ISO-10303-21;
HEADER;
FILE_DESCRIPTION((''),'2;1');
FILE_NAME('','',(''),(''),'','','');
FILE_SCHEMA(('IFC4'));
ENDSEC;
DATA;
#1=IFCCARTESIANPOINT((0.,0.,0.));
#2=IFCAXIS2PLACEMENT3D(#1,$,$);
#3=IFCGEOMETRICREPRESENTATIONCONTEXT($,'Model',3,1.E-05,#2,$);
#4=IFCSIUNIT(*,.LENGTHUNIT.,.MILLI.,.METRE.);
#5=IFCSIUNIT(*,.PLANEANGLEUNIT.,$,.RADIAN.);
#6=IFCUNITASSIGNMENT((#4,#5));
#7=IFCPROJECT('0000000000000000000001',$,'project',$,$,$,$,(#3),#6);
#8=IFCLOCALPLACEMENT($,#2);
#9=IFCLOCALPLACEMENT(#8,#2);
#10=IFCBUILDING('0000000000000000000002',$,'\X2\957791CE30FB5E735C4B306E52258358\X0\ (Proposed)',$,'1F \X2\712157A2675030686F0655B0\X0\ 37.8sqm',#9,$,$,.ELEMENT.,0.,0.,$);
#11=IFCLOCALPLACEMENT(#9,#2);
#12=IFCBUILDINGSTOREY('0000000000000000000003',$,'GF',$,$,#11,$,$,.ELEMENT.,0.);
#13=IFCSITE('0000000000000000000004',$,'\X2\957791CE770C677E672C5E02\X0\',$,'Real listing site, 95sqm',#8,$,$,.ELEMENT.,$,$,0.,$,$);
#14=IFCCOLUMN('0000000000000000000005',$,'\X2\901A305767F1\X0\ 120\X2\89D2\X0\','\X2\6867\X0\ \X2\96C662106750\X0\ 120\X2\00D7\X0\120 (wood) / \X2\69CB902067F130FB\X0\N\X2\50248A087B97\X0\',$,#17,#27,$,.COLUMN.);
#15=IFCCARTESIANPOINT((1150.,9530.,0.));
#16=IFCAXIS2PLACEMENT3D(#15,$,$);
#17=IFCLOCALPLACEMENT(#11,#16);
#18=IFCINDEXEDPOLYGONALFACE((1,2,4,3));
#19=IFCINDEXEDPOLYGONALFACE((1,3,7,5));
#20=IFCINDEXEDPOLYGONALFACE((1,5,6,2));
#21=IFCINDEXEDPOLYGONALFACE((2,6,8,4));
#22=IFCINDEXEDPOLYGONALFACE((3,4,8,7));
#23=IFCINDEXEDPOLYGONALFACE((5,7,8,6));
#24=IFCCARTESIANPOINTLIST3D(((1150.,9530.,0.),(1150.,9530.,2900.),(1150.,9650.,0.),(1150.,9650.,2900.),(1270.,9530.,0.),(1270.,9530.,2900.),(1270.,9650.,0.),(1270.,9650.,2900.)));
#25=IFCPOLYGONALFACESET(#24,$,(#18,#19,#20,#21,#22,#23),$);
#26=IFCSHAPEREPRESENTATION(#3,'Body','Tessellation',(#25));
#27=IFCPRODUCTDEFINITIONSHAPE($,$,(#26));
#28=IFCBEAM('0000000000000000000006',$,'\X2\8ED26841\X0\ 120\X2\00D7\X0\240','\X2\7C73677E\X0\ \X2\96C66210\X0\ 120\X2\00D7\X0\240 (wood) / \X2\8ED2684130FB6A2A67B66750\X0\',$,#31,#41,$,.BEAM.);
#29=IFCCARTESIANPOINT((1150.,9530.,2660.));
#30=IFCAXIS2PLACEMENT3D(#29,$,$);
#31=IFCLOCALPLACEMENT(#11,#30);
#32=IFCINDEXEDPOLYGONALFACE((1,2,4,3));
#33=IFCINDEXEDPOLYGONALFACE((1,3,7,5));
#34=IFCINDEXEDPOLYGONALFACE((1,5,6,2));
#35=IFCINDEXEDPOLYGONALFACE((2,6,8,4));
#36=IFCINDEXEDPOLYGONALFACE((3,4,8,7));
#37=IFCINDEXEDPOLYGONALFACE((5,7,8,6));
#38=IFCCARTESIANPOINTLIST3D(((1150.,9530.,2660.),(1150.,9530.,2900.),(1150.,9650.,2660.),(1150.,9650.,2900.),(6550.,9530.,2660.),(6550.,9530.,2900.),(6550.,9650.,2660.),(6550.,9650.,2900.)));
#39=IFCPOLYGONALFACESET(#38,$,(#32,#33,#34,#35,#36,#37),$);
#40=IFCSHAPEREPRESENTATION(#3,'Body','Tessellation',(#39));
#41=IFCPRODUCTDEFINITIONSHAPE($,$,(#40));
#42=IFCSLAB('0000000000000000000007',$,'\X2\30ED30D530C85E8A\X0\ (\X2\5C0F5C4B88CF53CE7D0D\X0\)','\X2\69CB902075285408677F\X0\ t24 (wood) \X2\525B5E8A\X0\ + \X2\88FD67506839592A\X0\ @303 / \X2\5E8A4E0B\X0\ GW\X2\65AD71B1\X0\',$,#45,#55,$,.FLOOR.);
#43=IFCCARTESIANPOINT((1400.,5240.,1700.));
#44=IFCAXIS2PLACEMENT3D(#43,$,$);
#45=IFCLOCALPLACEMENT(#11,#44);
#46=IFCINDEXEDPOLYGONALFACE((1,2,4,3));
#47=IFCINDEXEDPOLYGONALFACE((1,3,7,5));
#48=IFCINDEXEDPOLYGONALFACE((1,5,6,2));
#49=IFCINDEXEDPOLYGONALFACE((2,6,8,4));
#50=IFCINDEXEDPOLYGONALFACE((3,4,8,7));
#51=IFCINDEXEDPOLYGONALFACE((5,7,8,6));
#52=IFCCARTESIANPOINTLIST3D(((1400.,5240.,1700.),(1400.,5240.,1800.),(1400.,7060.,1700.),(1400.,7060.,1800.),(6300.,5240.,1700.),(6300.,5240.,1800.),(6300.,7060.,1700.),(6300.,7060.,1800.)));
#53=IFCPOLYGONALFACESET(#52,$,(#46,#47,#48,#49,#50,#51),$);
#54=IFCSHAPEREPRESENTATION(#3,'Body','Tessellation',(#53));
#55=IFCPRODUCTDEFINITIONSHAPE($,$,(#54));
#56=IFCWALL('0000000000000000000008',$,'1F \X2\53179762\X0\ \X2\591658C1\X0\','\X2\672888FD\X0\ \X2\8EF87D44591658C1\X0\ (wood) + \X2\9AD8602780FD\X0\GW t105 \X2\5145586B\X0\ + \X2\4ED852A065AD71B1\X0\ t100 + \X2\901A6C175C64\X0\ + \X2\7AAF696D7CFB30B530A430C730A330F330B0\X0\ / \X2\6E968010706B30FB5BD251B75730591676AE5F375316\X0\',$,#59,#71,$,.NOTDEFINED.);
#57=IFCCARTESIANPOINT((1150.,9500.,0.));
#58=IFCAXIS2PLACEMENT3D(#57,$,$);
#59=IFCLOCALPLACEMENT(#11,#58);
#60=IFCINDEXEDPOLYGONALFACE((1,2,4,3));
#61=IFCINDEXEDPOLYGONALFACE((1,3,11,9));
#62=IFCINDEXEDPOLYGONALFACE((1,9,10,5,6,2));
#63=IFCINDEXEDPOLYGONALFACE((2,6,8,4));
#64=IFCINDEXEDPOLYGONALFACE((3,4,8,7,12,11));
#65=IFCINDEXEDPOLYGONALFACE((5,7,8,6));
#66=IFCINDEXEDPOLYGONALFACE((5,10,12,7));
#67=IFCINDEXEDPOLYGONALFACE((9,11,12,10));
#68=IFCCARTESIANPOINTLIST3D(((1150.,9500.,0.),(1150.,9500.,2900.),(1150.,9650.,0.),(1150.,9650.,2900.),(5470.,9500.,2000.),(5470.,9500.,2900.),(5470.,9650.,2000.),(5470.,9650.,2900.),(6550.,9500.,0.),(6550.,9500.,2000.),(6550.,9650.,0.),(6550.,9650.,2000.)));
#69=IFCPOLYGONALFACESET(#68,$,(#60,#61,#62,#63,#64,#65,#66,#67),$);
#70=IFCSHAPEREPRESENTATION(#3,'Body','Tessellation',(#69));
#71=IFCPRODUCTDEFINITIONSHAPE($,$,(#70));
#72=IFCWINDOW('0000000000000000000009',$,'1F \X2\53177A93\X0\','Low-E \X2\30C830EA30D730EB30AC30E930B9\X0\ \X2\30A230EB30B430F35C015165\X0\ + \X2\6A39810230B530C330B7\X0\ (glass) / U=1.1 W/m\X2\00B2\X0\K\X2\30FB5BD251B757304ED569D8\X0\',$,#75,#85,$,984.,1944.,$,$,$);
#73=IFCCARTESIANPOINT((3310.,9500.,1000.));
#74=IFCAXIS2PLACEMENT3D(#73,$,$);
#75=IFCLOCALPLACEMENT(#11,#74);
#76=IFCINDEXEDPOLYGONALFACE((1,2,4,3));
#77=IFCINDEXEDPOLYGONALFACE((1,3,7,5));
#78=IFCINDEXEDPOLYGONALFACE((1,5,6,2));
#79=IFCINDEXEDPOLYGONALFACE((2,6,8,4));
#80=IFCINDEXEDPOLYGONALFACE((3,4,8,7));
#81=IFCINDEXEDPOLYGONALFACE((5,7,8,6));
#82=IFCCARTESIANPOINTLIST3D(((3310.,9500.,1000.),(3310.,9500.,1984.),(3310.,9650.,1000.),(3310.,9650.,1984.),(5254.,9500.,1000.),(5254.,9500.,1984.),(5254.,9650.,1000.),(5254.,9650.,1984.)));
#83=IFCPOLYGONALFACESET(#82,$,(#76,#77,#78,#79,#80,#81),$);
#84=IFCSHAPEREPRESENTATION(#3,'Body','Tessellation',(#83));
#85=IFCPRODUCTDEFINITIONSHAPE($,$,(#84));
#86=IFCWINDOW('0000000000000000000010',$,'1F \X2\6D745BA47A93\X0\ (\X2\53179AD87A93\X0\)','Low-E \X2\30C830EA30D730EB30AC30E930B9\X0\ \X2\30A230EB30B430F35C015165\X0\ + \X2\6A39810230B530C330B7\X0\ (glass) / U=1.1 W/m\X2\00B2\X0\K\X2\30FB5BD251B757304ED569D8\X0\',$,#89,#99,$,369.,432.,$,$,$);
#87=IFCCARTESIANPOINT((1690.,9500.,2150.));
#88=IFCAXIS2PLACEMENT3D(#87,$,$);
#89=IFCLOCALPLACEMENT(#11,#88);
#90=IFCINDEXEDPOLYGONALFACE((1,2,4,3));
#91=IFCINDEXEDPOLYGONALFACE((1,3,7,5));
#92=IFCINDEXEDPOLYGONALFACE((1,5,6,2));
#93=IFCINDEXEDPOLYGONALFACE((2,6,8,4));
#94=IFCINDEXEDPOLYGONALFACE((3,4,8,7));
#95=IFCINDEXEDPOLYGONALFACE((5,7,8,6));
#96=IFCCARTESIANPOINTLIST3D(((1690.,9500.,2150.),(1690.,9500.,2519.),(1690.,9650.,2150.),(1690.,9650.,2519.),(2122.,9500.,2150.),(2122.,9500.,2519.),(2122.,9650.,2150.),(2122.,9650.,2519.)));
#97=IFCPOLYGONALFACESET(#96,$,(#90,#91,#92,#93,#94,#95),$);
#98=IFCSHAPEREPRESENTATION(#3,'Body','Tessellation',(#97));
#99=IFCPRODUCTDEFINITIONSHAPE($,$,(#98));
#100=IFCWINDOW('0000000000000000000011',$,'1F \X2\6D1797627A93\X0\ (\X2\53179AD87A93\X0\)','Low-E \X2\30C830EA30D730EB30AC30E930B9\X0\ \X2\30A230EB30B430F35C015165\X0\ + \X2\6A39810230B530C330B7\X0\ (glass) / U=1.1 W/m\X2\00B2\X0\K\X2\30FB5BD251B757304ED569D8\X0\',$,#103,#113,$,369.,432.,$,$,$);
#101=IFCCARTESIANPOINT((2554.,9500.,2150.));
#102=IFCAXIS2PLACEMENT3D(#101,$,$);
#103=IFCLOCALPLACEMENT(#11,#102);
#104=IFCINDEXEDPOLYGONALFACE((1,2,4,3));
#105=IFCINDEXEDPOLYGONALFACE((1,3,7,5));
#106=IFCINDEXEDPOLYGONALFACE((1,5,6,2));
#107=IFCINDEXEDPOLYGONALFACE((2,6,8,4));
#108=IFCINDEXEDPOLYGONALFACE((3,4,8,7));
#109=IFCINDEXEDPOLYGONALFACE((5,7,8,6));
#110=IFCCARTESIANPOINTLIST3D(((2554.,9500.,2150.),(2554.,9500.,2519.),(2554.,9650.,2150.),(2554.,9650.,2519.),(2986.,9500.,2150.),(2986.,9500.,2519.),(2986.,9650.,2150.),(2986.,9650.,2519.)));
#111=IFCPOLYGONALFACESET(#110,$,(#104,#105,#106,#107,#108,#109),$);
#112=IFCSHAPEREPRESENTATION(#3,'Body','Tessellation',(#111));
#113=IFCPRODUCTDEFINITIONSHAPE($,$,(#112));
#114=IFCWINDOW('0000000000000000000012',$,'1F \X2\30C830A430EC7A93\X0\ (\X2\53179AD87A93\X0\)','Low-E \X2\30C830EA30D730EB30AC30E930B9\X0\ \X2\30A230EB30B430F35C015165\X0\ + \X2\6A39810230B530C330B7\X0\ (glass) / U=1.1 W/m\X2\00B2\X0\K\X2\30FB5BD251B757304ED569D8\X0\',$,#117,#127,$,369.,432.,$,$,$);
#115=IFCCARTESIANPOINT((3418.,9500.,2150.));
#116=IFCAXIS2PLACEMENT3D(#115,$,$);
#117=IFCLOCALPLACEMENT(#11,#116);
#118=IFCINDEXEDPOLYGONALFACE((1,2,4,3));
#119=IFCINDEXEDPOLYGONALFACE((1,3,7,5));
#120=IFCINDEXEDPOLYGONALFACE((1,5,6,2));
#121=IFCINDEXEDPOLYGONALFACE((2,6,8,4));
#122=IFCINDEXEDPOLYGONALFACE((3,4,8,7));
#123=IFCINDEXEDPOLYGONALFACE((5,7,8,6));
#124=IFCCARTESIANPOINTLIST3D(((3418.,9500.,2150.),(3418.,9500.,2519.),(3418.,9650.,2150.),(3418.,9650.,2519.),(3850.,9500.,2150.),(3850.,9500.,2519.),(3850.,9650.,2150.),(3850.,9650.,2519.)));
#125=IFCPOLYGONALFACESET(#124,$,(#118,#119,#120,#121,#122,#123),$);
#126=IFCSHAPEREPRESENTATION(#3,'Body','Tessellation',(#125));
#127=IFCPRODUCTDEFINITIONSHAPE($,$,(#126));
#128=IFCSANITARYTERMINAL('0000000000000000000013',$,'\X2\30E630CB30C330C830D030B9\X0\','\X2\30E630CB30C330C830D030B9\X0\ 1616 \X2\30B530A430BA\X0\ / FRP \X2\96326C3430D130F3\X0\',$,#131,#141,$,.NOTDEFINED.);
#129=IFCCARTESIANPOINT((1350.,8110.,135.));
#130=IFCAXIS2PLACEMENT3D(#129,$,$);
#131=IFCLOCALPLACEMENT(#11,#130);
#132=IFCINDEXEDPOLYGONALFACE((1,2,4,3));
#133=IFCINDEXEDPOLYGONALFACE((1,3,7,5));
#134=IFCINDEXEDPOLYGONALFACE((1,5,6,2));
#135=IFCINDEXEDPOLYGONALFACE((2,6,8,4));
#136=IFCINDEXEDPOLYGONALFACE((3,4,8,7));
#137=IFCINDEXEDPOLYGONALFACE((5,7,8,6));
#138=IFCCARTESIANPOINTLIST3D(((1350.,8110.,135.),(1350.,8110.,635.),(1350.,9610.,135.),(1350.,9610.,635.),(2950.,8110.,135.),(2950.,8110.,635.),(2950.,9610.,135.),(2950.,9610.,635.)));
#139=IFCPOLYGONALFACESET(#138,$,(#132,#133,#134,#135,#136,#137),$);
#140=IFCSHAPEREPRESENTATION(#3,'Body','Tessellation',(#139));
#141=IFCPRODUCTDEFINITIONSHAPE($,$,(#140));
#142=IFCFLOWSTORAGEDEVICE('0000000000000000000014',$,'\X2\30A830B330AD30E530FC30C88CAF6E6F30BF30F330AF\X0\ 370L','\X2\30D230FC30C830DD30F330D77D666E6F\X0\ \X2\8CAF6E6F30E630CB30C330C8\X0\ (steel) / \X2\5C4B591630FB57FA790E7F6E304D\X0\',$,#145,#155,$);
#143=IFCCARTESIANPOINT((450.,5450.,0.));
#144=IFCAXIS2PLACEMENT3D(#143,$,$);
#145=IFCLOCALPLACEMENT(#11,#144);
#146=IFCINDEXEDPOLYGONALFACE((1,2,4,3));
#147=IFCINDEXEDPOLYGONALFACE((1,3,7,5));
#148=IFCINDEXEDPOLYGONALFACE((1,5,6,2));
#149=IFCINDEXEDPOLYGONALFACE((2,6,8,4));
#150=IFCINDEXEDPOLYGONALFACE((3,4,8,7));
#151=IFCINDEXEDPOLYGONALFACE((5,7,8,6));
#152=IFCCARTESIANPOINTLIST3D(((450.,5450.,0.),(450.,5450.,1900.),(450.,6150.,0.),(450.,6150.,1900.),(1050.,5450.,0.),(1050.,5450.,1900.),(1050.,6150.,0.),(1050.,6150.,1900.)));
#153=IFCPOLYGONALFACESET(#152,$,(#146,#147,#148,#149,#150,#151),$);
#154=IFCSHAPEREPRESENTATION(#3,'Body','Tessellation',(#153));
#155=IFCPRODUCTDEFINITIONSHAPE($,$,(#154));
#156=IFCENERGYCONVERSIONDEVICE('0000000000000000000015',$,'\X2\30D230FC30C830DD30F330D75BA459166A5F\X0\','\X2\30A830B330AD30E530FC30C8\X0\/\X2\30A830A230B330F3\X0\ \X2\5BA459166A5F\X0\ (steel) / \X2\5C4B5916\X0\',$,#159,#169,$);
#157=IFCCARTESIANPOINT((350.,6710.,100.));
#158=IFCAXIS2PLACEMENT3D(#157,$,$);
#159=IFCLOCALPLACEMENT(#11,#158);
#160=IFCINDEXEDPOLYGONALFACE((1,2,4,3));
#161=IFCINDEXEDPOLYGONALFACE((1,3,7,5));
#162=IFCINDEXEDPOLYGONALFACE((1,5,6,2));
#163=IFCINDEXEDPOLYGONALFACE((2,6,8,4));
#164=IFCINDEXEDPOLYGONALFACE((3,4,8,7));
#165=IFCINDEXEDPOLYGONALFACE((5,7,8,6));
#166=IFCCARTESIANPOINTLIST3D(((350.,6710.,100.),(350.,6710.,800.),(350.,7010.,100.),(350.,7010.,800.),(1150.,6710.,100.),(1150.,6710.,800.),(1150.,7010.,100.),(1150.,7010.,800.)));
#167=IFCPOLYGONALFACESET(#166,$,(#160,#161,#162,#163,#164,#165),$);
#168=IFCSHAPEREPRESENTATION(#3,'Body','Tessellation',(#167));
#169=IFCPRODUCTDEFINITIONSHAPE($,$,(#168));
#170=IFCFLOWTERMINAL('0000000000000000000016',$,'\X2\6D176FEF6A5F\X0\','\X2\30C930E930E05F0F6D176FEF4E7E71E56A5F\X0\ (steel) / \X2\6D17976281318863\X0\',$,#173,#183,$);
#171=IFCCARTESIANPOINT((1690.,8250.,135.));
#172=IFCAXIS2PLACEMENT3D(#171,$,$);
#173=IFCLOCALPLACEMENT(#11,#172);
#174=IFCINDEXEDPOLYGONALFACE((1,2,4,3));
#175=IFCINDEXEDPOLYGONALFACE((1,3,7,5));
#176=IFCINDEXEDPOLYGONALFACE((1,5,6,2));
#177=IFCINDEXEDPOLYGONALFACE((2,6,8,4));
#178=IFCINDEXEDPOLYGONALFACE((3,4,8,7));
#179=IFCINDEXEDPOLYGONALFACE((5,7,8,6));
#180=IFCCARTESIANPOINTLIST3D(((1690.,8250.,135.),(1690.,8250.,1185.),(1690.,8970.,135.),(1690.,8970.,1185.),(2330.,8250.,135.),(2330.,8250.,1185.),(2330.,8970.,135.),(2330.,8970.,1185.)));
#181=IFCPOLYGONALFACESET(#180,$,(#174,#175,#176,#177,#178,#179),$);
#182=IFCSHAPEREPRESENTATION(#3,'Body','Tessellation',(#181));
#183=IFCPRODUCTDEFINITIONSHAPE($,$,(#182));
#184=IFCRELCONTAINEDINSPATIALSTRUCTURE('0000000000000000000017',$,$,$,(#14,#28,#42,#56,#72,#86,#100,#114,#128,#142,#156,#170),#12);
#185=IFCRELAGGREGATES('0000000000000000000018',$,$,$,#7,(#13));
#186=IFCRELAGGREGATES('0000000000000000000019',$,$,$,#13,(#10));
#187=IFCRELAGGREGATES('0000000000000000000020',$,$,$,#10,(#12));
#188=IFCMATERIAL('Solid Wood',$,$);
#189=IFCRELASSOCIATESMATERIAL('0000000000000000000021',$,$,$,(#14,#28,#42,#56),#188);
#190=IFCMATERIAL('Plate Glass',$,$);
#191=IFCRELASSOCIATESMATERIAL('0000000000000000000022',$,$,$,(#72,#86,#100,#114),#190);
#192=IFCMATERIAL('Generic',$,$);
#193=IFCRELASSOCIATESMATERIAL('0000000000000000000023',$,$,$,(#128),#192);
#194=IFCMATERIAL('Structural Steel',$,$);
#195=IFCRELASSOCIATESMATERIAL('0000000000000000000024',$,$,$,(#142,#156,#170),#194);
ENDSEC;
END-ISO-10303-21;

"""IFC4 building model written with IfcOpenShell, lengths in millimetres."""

from ifc_helpers import new_model, si_unit, frame, frame_2d, origin, place, context, project, spatial, rectangle, extrude, material, element, fill, save


model = new_model("IFC4")

# Units and contexts
model_context = context("Model", 3, precision=1e-05, world=origin())
ifc_project = project(units=[si_unit("LENGTHUNIT", "METRE", prefix="MILLI"), si_unit("PLANEANGLEUNIT", "RADIAN")], contexts=[model_context])

# Site, building, storey
site_placement = place(None, origin())
site = spatial("IfcSite", under=ifc_project, at=site_placement, Name="長野県松本市", ObjectType="Real listing site, 95sqm", CompositionType="ELEMENT", RefElevation=0.0)
building_placement = place(site_placement, origin())
building = spatial("IfcBuilding", under=site, at=building_placement, Name="長野・平屋の別荘 (Proposed)", ObjectType="1F 無垢材と漆喰 37.8sqm", CompositionType="ELEMENT", ElevationOfRefHeight=0.0, ElevationOfTerrain=0.0)
storey_placement = place(building_placement, origin())
storey = spatial("IfcBuildingStorey", under=building, at=storey_placement, Name="GF", CompositionType="ELEMENT", Elevation=0.0)

# Column
ifc_material_1 = material(Name="Solid Wood")
column_1_placement = place(storey_placement, frame((1150.0, 9530.0, 0.0)))
element("IfcColumn", 1, at=column_1_placement, inside=storey, material=ifc_material_1, Name="通し柱 120角", Description="桧 集成材 120×120 (wood) / 構造柱・N値計算", PredefinedType="COLUMN", context=model_context, shape_type="SweptSolid", body=[
    extrude(rectangle(XDim=120.0, YDim=120.0, at=frame_2d((60.0, 60.0))), frame((1150.0, 9530.0, 0.0)), (0.0, 0.0, 1.0), 2900.0),
])

# Beam
beam_1_placement = place(storey_placement, frame((1150.0, 9530.0, 2660.0)))
element("IfcBeam", 2, at=beam_1_placement, inside=storey, material=ifc_material_1, Name="軒桁 120×240", Description="米松 集成 120×240 (wood) / 軒桁・横架材", PredefinedType="BEAM", context=model_context, shape_type="SweptSolid", body=[
    extrude(rectangle(XDim=5400.0, YDim=120.0, at=frame_2d((2700.0, 60.0))), frame((1150.0, 9530.0, 2660.0)), (0.0, 0.0, 1.0), 240.0),
])

# Slab
slab_placement = place(storey_placement, frame((1400.0, 5240.0, 1700.0)))
element("IfcSlab", 3, at=slab_placement, inside=storey, material=ifc_material_1, Name="ロフト床 (小屋裏収納)", Description="構造用合板 t24 (wood) 剛床 + 製材根太 @303 / 床下 GW断熱", PredefinedType="FLOOR", context=model_context, shape_type="SweptSolid", body=[
    extrude(rectangle(XDim=4900.0, YDim=1820.0, at=frame_2d((2450.0, 910.0))), frame((1400.0, 5240.0, 1700.0)), (0.0, 0.0, 1.0), 100.0),
])

# Wall, openings, windows
wall_1_placement = place(storey_placement, frame((1150.0, 9500.0, 0.0)))
wall_1 = element("IfcWall", 4, at=wall_1_placement, inside=storey, material=ifc_material_1, Name="1F 北面 外壁", Description="木製 軸組外壁 (wood) + 高性能GW t105 充填 + 付加断熱 t100 + 通気層 + 窯業系サイディング / 準耐火・寒冷地外皮強化", PredefinedType="NOTDEFINED", context=model_context, shape_type="SweptSolid", body=[
    extrude(rectangle(XDim=5400.0, YDim=150.0, at=frame_2d((2700.0, 75.0))), frame((1150.0, 9500.0, 0.0)), (0.0, 0.0, 1.0), 2900.0),
])
opening_1_placement = place(storey_placement, frame((3310.0, 9500.0, 1000.0)))
opening_1 = element("IfcOpeningElement", 5, at=opening_1_placement, cuts=wall_1, PredefinedType="NOTDEFINED", context=model_context, shape_type="SweptSolid", body=[
    extrude(rectangle(XDim=1944.0, YDim=150.0, at=frame_2d((972.0, 75.0))), frame((3310.0, 9500.0, 1000.0)), (0.0, 0.0, 1.0), 984.0),
])
opening_2_placement = place(storey_placement, frame((1690.0, 9500.0, 2150.0)))
opening_2 = element("IfcOpeningElement", 6, at=opening_2_placement, cuts=wall_1, PredefinedType="NOTDEFINED", context=model_context, shape_type="SweptSolid", body=[
    extrude(rectangle(XDim=432.0, YDim=150.0, at=frame_2d((216.0, 75.0))), frame((1690.0, 9500.0, 2150.0)), (0.0, 0.0, 1.0), 369.0),
])
opening_3_placement = place(storey_placement, frame((2554.0, 9500.0, 2150.0)))
opening_3 = element("IfcOpeningElement", 7, at=opening_3_placement, cuts=wall_1, PredefinedType="NOTDEFINED", context=model_context, shape_type="SweptSolid", body=[
    extrude(rectangle(XDim=432.0, YDim=150.0, at=frame_2d((216.0, 75.0))), frame((2554.0, 9500.0, 2150.0)), (0.0, 0.0, 1.0), 369.0),
])
opening_4_placement = place(storey_placement, frame((3418.0, 9500.0, 2150.0)))
opening_4 = element("IfcOpeningElement", 8, at=opening_4_placement, cuts=wall_1, PredefinedType="NOTDEFINED", context=model_context, shape_type="SweptSolid", body=[
    extrude(rectangle(XDim=432.0, YDim=150.0, at=frame_2d((216.0, 75.0))), frame((3418.0, 9500.0, 2150.0)), (0.0, 0.0, 1.0), 369.0),
])
ifc_material_2 = material(Name="Plate Glass")
window_1_placement = place(storey_placement, frame((3310.0, 9500.0, 1000.0)))
window_1 = element("IfcWindow", 9, at=window_1_placement, inside=storey, material=ifc_material_2, Name="1F 北窓", Description="Low-E トリプルガラス アルゴン封入 + 樹脂サッシ (glass) / U=1.1 W/m²K・寒冷地仕様", OverallHeight=984.0, OverallWidth=1944.0, context=model_context, shape_type="SweptSolid", body=[
    extrude(rectangle(XDim=1944.0, YDim=150.0, at=frame_2d((972.0, 75.0))), frame((3310.0, 9500.0, 1000.0)), (0.0, 0.0, 1.0), 984.0),
])
fill(opening_1, window_1)
window_2_placement = place(storey_placement, frame((1690.0, 9500.0, 2150.0)))
window_2 = element("IfcWindow", 10, at=window_2_placement, inside=storey, material=ifc_material_2, Name="1F 浴室窓 (北高窓)", Description="Low-E トリプルガラス アルゴン封入 + 樹脂サッシ (glass) / U=1.1 W/m²K・寒冷地仕様", OverallHeight=369.0, OverallWidth=432.0, context=model_context, shape_type="SweptSolid", body=[
    extrude(rectangle(XDim=432.0, YDim=150.0, at=frame_2d((216.0, 75.0))), frame((1690.0, 9500.0, 2150.0)), (0.0, 0.0, 1.0), 369.0),
])
fill(opening_2, window_2)
window_3_placement = place(storey_placement, frame((2554.0, 9500.0, 2150.0)))
window_3 = element("IfcWindow", 11, at=window_3_placement, inside=storey, material=ifc_material_2, Name="1F 洗面窓 (北高窓)", Description="Low-E トリプルガラス アルゴン封入 + 樹脂サッシ (glass) / U=1.1 W/m²K・寒冷地仕様", OverallHeight=369.0, OverallWidth=432.0, context=model_context, shape_type="SweptSolid", body=[
    extrude(rectangle(XDim=432.0, YDim=150.0, at=frame_2d((216.0, 75.0))), frame((2554.0, 9500.0, 2150.0)), (0.0, 0.0, 1.0), 369.0),
])
fill(opening_3, window_3)
window_4_placement = place(storey_placement, frame((3418.0, 9500.0, 2150.0)))
window_4 = element("IfcWindow", 12, at=window_4_placement, inside=storey, material=ifc_material_2, Name="1F トイレ窓 (北高窓)", Description="Low-E トリプルガラス アルゴン封入 + 樹脂サッシ (glass) / U=1.1 W/m²K・寒冷地仕様", OverallHeight=369.0, OverallWidth=432.0, context=model_context, shape_type="SweptSolid", body=[
    extrude(rectangle(XDim=432.0, YDim=150.0, at=frame_2d((216.0, 75.0))), frame((3418.0, 9500.0, 2150.0)), (0.0, 0.0, 1.0), 369.0),
])
fill(opening_4, window_4)

# Sanitary terminal
ifc_material_3 = material(Name="Generic")
sanitary_terminal_placement = place(storey_placement, frame((1350.0, 8110.0, 135.0)))
element("IfcSanitaryTerminal", 13, at=sanitary_terminal_placement, inside=storey, material=ifc_material_3, Name="ユニットバス", Description="ユニットバス 1616 サイズ / FRP 防水パン", PredefinedType="NOTDEFINED", context=model_context, shape_type="SweptSolid", body=[
    extrude(rectangle(XDim=1600.0, YDim=1500.0, at=frame_2d((800.0, 750.0))), frame((1350.0, 8110.0, 135.0)), (0.0, 0.0, 1.0), 500.0),
])

# Flow storage device
ifc_material_4 = material(Name="Structural Steel")
flow_storage_device_placement = place(storey_placement, frame((450.0, 5450.0, 0.0)))
element("IfcFlowStorageDevice", 14, at=flow_storage_device_placement, inside=storey, material=ifc_material_4, Name="エコキュート貯湯タンク 370L", Description="ヒートポンプ給湯 貯湯ユニット (steel) / 屋外・基礎置き", context=model_context, shape_type="SweptSolid", body=[
    extrude(rectangle(XDim=600.0, YDim=700.0, at=frame_2d((300.0, 350.0))), frame((450.0, 5450.0, 0.0)), (0.0, 0.0, 1.0), 1900.0),
])

# Energy conversion device
energy_conversion_device_placement = place(storey_placement, frame((350.0, 6710.0, 100.0)))
element("IfcEnergyConversionDevice", 15, at=energy_conversion_device_placement, inside=storey, material=ifc_material_4, Name="ヒートポンプ室外機", Description="エコキュート/エアコン 室外機 (steel) / 屋外", context=model_context, shape_type="SweptSolid", body=[
    extrude(rectangle(XDim=800.0, YDim=300.0, at=frame_2d((400.0, 150.0))), frame((350.0, 6710.0, 100.0)), (0.0, 0.0, 1.0), 700.0),
])

# Flow terminal
flow_terminal_placement = place(storey_placement, frame((1690.0, 8250.0, 135.0)))
element("IfcFlowTerminal", 16, at=flow_terminal_placement, inside=storey, material=ifc_material_4, Name="洗濯機", Description="ドラム式洗濯乾燥機 (steel) / 洗面脱衣", context=model_context, shape_type="SweptSolid", body=[
    extrude(rectangle(XDim=640.0, YDim=720.0, at=frame_2d((320.0, 360.0))), frame((1690.0, 8250.0, 135.0)), (0.0, 0.0, 1.0), 1050.0),
])

save(model, "model.ifc")
